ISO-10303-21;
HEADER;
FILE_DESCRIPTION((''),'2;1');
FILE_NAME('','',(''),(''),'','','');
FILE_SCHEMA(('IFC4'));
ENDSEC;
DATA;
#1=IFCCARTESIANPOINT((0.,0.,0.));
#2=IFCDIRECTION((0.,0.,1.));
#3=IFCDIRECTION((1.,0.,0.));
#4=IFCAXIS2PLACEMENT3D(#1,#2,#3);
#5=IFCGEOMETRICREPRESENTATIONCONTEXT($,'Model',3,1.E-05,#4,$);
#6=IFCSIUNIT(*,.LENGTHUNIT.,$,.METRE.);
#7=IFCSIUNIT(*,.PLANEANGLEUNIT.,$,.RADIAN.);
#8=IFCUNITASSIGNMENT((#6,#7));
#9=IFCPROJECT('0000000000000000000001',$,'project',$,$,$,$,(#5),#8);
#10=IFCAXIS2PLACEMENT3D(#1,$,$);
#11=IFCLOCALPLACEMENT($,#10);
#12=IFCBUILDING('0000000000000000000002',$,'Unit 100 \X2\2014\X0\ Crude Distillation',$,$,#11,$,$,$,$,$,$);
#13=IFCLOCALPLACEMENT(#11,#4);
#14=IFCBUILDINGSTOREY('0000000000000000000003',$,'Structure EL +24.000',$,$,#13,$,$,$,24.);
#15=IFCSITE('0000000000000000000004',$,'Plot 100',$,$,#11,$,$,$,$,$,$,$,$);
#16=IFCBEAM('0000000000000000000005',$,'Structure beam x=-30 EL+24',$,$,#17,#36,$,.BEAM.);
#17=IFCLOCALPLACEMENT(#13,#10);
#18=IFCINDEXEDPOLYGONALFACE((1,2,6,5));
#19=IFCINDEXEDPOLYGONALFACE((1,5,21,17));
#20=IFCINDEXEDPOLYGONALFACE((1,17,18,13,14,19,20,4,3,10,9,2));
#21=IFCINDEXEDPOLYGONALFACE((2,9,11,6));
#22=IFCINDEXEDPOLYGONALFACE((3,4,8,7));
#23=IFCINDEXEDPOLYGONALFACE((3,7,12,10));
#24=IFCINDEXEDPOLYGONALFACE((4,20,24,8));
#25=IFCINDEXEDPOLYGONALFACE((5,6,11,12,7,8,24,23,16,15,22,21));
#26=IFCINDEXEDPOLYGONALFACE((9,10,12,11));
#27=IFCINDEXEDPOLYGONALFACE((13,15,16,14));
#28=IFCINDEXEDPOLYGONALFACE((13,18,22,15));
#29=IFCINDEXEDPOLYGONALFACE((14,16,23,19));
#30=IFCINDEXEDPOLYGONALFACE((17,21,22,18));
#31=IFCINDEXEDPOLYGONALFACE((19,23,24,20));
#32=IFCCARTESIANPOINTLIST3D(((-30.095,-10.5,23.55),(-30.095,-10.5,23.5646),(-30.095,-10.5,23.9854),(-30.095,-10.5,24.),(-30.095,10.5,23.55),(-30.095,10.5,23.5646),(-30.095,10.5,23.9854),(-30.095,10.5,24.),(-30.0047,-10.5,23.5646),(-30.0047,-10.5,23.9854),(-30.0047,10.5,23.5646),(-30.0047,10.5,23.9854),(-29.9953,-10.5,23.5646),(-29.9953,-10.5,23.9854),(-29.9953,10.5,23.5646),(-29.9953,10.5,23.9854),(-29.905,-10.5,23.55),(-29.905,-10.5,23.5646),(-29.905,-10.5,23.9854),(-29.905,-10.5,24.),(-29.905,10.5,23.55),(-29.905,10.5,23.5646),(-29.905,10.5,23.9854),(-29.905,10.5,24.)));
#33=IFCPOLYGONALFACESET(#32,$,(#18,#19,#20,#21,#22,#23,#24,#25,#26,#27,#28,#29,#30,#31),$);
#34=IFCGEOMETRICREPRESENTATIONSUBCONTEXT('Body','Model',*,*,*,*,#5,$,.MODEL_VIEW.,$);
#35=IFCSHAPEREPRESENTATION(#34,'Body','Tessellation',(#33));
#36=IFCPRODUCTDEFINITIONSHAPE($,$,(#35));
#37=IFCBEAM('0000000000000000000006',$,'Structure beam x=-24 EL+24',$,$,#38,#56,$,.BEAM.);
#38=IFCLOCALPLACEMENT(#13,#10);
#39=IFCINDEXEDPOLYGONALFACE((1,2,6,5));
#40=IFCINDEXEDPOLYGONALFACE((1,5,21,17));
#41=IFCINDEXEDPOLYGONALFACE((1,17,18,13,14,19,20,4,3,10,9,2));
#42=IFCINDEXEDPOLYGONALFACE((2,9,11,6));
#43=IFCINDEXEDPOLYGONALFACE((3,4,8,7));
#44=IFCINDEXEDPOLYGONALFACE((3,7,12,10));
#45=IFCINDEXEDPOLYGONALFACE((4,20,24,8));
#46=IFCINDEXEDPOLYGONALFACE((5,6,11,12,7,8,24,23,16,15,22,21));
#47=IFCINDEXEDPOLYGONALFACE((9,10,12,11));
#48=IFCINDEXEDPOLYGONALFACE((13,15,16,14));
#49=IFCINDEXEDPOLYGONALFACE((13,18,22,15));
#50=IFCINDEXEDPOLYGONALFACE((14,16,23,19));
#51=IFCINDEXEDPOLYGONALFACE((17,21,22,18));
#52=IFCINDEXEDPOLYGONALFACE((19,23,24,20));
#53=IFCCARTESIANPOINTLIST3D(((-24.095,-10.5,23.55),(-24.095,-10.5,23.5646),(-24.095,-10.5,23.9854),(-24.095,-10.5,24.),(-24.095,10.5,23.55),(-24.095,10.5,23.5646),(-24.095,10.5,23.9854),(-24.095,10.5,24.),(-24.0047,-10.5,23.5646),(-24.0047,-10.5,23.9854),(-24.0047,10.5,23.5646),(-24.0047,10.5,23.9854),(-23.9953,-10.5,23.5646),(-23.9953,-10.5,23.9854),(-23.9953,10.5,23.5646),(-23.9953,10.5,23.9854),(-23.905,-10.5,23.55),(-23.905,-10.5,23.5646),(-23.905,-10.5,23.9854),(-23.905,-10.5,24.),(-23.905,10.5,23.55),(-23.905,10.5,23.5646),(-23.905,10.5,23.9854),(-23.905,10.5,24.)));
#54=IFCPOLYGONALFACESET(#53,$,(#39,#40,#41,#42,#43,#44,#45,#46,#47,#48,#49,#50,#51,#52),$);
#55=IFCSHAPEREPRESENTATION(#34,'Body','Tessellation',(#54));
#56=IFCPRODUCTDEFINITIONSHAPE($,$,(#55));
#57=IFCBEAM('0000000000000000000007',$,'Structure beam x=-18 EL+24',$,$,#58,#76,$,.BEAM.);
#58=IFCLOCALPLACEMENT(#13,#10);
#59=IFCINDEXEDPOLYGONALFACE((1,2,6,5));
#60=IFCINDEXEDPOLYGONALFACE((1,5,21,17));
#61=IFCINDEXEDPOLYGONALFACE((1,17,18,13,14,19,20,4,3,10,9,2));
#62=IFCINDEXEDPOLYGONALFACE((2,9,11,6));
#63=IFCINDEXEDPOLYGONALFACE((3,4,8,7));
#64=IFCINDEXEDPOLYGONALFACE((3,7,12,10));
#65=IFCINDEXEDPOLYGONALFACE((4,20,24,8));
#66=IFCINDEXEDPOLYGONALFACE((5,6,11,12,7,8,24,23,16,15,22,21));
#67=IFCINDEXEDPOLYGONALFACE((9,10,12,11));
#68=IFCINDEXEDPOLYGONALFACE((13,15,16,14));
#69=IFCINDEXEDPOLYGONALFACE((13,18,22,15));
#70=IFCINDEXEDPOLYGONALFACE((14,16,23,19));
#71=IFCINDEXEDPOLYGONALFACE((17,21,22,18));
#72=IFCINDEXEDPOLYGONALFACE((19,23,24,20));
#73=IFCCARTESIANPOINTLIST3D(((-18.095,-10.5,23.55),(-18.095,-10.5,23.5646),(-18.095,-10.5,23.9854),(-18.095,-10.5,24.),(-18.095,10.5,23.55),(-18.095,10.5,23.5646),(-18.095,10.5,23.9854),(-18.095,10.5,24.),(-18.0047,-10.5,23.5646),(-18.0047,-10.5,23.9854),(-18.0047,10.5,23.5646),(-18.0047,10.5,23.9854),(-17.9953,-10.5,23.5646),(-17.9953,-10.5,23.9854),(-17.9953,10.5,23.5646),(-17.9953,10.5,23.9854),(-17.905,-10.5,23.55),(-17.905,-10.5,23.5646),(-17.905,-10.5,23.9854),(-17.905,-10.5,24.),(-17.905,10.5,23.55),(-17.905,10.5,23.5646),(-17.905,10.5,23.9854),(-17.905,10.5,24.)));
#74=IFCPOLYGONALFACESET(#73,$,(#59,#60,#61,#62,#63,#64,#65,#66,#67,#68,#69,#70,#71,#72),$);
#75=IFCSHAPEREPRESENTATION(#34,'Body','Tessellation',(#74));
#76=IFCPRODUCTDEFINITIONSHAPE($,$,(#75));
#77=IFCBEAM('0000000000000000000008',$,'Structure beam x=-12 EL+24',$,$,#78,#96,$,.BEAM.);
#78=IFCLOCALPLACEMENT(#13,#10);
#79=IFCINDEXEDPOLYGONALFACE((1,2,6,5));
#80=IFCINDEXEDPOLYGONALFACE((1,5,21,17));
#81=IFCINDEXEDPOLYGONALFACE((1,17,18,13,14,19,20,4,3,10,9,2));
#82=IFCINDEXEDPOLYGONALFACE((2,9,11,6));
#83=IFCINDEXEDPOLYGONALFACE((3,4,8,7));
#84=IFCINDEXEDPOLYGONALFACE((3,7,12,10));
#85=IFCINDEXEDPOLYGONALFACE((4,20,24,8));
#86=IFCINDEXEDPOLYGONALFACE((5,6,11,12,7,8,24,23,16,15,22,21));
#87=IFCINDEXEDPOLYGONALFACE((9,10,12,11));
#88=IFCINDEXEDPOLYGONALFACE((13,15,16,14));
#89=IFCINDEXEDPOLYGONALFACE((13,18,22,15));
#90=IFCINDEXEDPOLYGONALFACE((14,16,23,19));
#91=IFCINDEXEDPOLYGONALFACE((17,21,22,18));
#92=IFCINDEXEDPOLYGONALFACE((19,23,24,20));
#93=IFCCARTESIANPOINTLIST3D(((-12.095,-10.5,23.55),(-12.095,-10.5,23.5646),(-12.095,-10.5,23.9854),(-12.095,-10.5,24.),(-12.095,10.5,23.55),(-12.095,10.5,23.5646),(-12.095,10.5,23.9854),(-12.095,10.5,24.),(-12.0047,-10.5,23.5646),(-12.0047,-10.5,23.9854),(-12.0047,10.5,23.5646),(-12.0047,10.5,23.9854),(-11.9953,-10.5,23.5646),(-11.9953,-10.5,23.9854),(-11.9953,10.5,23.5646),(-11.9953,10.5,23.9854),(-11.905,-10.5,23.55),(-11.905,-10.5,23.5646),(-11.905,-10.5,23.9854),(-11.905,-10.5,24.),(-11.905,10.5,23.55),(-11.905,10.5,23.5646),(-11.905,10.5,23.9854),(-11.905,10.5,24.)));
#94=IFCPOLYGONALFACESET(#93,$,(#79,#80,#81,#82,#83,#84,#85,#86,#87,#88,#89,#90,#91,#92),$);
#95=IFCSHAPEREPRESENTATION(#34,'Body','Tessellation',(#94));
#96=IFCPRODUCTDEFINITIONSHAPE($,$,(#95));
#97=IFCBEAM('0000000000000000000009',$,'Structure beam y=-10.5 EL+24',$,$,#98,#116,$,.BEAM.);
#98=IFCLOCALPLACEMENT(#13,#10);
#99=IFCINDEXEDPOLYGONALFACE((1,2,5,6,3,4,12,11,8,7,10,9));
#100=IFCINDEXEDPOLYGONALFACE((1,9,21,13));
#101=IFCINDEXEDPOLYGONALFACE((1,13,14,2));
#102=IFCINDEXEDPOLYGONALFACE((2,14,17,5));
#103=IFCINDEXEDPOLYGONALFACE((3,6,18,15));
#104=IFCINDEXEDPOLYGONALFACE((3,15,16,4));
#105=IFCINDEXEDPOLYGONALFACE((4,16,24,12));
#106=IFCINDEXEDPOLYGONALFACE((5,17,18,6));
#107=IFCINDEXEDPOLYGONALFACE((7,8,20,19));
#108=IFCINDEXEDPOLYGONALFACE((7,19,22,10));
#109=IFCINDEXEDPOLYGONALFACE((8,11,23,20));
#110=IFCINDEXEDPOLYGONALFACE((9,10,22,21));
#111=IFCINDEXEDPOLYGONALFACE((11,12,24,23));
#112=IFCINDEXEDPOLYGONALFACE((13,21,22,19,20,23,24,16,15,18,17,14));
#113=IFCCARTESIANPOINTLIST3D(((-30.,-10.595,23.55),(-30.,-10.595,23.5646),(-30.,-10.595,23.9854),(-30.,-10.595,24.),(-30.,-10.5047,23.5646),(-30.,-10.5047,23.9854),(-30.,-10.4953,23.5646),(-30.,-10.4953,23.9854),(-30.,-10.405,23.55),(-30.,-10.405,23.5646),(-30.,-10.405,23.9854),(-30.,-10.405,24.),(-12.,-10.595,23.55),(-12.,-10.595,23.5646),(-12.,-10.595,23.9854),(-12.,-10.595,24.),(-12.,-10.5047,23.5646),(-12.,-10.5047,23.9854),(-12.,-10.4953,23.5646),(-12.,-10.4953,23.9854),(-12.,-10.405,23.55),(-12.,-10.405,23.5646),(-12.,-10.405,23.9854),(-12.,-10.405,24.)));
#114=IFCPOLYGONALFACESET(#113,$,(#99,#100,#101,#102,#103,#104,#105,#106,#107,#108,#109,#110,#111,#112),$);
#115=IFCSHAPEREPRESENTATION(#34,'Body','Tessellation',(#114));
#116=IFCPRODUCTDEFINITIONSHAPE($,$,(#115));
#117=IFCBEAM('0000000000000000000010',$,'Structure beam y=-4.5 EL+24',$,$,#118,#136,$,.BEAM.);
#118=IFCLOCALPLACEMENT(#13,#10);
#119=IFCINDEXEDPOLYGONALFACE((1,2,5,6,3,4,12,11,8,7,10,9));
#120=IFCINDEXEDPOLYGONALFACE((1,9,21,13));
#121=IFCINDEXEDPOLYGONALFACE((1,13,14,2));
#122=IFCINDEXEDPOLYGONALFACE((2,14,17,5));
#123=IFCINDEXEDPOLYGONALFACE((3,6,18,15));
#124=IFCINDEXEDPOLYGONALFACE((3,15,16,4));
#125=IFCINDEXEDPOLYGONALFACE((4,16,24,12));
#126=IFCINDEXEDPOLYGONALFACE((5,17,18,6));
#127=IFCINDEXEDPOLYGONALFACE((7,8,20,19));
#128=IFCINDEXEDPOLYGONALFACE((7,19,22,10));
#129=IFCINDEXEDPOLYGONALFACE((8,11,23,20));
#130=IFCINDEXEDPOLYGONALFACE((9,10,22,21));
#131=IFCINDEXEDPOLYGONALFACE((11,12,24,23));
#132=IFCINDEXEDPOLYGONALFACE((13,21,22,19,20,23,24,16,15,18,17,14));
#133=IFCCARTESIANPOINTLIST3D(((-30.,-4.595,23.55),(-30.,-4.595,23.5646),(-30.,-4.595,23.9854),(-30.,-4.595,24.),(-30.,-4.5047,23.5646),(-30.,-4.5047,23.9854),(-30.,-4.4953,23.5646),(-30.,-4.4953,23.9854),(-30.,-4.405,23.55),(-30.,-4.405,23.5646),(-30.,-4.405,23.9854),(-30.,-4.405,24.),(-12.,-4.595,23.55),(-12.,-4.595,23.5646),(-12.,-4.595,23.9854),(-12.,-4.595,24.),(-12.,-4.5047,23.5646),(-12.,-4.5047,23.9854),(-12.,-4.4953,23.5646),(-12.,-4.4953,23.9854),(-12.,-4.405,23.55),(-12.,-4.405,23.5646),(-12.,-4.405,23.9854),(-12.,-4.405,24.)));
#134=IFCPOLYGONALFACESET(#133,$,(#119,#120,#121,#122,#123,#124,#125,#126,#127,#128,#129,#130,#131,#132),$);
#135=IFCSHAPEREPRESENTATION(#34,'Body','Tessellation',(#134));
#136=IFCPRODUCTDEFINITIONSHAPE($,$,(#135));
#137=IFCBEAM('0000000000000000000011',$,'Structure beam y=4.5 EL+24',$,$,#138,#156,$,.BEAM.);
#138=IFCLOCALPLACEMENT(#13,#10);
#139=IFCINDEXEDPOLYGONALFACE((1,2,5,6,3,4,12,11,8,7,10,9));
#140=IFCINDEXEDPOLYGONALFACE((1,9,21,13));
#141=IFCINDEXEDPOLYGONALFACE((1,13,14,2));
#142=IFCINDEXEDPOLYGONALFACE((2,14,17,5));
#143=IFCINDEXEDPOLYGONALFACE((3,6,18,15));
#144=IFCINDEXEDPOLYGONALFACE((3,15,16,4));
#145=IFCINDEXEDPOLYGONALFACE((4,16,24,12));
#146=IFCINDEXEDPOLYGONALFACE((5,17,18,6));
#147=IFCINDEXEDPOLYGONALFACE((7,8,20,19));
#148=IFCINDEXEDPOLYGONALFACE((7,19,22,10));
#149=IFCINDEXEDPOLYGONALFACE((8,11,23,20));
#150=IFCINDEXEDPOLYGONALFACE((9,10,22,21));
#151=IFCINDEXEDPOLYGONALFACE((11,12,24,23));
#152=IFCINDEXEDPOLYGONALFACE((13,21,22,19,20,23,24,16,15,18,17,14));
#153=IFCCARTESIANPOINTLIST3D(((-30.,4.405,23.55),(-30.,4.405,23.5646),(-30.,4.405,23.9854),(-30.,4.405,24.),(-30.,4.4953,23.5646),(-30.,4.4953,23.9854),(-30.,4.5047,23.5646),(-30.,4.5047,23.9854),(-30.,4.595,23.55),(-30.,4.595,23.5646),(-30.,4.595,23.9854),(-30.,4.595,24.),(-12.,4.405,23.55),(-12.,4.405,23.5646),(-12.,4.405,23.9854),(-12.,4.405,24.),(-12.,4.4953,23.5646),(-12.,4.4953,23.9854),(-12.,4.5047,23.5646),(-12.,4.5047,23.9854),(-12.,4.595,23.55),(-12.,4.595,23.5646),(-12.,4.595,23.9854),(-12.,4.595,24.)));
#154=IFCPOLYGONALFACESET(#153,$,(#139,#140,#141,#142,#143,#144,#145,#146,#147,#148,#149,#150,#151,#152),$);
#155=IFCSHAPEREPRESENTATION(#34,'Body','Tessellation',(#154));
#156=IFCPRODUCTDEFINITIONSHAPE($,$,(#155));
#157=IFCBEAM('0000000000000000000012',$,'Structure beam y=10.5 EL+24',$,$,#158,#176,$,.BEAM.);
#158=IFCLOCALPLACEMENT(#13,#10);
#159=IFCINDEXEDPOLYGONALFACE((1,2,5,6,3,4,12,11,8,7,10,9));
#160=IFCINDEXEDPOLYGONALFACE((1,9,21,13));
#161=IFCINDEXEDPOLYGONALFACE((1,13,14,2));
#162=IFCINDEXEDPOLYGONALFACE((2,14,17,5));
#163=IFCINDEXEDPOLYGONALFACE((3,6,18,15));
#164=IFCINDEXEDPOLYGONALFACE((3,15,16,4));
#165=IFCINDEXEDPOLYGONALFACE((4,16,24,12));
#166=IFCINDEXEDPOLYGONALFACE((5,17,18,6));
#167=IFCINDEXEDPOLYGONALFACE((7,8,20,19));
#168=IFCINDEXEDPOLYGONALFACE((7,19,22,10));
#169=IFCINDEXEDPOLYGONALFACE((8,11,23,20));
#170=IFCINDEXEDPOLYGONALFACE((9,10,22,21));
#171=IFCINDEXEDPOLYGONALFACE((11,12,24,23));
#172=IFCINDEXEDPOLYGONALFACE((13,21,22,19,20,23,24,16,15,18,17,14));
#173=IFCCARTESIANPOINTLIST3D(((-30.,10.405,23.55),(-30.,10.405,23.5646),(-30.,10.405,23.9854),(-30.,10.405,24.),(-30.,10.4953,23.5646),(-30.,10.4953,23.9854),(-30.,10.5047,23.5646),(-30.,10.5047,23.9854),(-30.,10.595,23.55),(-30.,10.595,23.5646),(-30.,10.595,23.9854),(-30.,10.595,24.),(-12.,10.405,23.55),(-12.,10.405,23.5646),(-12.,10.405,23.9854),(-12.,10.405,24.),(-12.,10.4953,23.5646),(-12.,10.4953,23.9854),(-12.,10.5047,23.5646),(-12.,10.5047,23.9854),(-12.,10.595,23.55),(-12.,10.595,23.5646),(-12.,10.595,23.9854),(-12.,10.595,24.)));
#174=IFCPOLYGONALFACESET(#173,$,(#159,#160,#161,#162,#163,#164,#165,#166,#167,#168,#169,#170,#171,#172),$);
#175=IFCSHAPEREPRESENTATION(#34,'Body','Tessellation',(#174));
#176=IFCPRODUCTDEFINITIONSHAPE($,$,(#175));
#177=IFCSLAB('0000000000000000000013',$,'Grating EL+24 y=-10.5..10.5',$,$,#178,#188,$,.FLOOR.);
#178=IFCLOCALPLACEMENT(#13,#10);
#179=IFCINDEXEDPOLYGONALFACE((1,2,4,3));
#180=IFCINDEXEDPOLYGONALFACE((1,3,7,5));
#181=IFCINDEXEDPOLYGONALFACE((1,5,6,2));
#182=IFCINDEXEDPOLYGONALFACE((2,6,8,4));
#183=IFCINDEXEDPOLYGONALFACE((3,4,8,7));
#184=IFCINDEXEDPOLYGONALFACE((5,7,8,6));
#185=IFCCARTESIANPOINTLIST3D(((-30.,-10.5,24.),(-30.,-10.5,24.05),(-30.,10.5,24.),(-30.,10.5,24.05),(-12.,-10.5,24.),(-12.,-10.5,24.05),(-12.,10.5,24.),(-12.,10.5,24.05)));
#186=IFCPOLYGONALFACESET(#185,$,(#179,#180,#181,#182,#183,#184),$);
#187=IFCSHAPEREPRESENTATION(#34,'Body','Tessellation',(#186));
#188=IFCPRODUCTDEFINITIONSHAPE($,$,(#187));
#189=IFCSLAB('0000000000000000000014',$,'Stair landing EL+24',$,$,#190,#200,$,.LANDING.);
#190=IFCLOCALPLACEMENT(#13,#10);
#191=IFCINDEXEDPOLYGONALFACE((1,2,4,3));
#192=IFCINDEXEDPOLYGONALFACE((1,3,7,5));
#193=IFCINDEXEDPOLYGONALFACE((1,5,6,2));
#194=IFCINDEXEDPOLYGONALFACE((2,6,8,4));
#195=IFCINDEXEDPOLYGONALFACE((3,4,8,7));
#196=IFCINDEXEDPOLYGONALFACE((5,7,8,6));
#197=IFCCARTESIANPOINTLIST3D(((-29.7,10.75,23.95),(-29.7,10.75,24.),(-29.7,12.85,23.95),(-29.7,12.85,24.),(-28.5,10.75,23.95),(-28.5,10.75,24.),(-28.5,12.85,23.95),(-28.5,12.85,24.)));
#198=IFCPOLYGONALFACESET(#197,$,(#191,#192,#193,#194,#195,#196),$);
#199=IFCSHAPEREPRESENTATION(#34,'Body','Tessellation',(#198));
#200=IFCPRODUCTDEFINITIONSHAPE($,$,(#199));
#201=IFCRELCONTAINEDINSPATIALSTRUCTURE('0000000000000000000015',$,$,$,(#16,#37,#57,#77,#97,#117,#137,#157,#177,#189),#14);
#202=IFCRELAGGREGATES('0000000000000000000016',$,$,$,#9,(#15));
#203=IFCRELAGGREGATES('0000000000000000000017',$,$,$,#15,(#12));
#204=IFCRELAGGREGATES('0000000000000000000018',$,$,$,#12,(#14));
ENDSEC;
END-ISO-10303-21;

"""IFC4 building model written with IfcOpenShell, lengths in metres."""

from ifc_helpers import new_model, si_unit, frame, origin, origin_with_axes, origin_2d, place, context, subcontext, project, spatial, rectangle, i_section, extrude, element, save


model = new_model("IFC4")

# Units and contexts
model_context = context("Model", 3, precision=1e-05, world=origin_with_axes())
body_context = subcontext(model_context, "Body", "Model", "MODEL_VIEW")
ifc_project = project(units=[si_unit("LENGTHUNIT", "METRE"), si_unit("PLANEANGLEUNIT", "RADIAN")], contexts=[model_context])

# Site, building, storey
placement = place(None, origin())
site = spatial("IfcSite", under=ifc_project, at=placement, Name="Plot 100")
building = spatial("IfcBuilding", under=site, at=placement, Name="Unit 100 — Crude Distillation")
storey_placement = place(placement, origin_with_axes())
storey = spatial("IfcBuildingStorey", under=building, at=storey_placement, Name="Structure EL +24.000", Elevation=24.0)

# Beams
beam_1_placement = place(storey_placement, origin_with_axes())
element("IfcBeam", 1, at=beam_1_placement, inside=storey, Name="Structure beam x=-30 EL+24", PredefinedType="BEAM", context=body_context, shape_type="SweptSolid", body=[
    extrude(i_section(OverallWidth=0.19, OverallDepth=0.45, WebThickness=0.0094, FlangeThickness=0.0146, at=origin_2d()), frame((-30.0, -10.5, 23.775), z_axis=(0.0, 1.0, 0.0), x_axis=(-1.0, 0.0, 0.0)), (0.0, 0.0, 1.0), 21.0),
])
beam_2_placement = place(storey_placement, origin_with_axes())
element("IfcBeam", 2, at=beam_2_placement, inside=storey, Name="Structure beam x=-24 EL+24", PredefinedType="BEAM", context=body_context, shape_type="SweptSolid", body=[
    extrude(i_section(OverallWidth=0.19, OverallDepth=0.45, WebThickness=0.0094, FlangeThickness=0.0146, at=origin_2d()), frame((-24.0, -10.5, 23.775), z_axis=(0.0, 1.0, 0.0), x_axis=(-1.0, 0.0, 0.0)), (0.0, 0.0, 1.0), 21.0),
])
beam_3_placement = place(storey_placement, origin_with_axes())
element("IfcBeam", 3, at=beam_3_placement, inside=storey, Name="Structure beam x=-18 EL+24", PredefinedType="BEAM", context=body_context, shape_type="SweptSolid", body=[
    extrude(i_section(OverallWidth=0.19, OverallDepth=0.45, WebThickness=0.0094, FlangeThickness=0.0146, at=origin_2d()), frame((-18.0, -10.5, 23.775), z_axis=(0.0, 1.0, 0.0), x_axis=(-1.0, 0.0, 0.0)), (0.0, 0.0, 1.0), 21.0),
])
beam_4_placement = place(storey_placement, origin_with_axes())
element("IfcBeam", 4, at=beam_4_placement, inside=storey, Name="Structure beam x=-12 EL+24", PredefinedType="BEAM", context=body_context, shape_type="SweptSolid", body=[
    extrude(i_section(OverallWidth=0.19, OverallDepth=0.45, WebThickness=0.0094, FlangeThickness=0.0146, at=origin_2d()), frame((-12.0, -10.5, 23.775), z_axis=(0.0, 1.0, 0.0), x_axis=(-1.0, 0.0, 0.0)), (0.0, 0.0, 1.0), 21.0),
])
beam_5_placement = place(storey_placement, origin_with_axes())
element("IfcBeam", 5, at=beam_5_placement, inside=storey, Name="Structure beam y=-10.5 EL+24", PredefinedType="BEAM", context=body_context, shape_type="SweptSolid", body=[
    extrude(i_section(OverallWidth=0.19, OverallDepth=0.45, WebThickness=0.0094, FlangeThickness=0.0146, at=origin_2d()), frame((-30.0, -10.5, 23.775), z_axis=(1.0, 0.0, 0.0), x_axis=(0.0, 1.0, 0.0)), (0.0, 0.0, 1.0), 18.0),
])
beam_6_placement = place(storey_placement, origin_with_axes())
element("IfcBeam", 6, at=beam_6_placement, inside=storey, Name="Structure beam y=-4.5 EL+24", PredefinedType="BEAM", context=body_context, shape_type="SweptSolid", body=[
    extrude(i_section(OverallWidth=0.19, OverallDepth=0.45, WebThickness=0.0094, FlangeThickness=0.0146, at=origin_2d()), frame((-30.0, -4.5, 23.775), z_axis=(1.0, 0.0, 0.0), x_axis=(0.0, 1.0, 0.0)), (0.0, 0.0, 1.0), 18.0),
])
beam_7_placement = place(storey_placement, origin_with_axes())
element("IfcBeam", 7, at=beam_7_placement, inside=storey, Name="Structure beam y=4.5 EL+24", PredefinedType="BEAM", context=body_context, shape_type="SweptSolid", body=[
    extrude(i_section(OverallWidth=0.19, OverallDepth=0.45, WebThickness=0.0094, FlangeThickness=0.0146, at=origin_2d()), frame((-30.0, 4.5, 23.775), z_axis=(1.0, 0.0, 0.0), x_axis=(0.0, 1.0, 0.0)), (0.0, 0.0, 1.0), 18.0),
])
beam_8_placement = place(storey_placement, origin_with_axes())
element("IfcBeam", 8, at=beam_8_placement, inside=storey, Name="Structure beam y=10.5 EL+24", PredefinedType="BEAM", context=body_context, shape_type="SweptSolid", body=[
    extrude(i_section(OverallWidth=0.19, OverallDepth=0.45, WebThickness=0.0094, FlangeThickness=0.0146, at=origin_2d()), frame((-30.0, 10.5, 23.775), z_axis=(1.0, 0.0, 0.0), x_axis=(0.0, 1.0, 0.0)), (0.0, 0.0, 1.0), 18.0),
])

# Slabs
slab_1_placement = place(storey_placement, origin_with_axes())
element("IfcSlab", 9, at=slab_1_placement, inside=storey, Name="Grating EL+24 y=-10.5..10.5", PredefinedType="FLOOR", context=body_context, shape_type="SweptSolid", body=[
    extrude(rectangle(XDim=18.0, YDim=21.0, at=origin_2d()), frame((-21.0, 0.0, 24.0), z_axis=(0.0, 0.0, 1.0), x_axis=(1.0, 0.0, 0.0)), (0.0, 0.0, 1.0), 0.05),
])
slab_2_placement = place(storey_placement, origin_with_axes())
element("IfcSlab", 10, at=slab_2_placement, inside=storey, Name="Stair landing EL+24", PredefinedType="LANDING", context=body_context, shape_type="SweptSolid", body=[
    extrude(rectangle(XDim=1.2, YDim=2.1, at=origin_2d()), frame((-29.1, 11.8, 23.95), z_axis=(0.0, 0.0, 1.0), x_axis=(1.0, 0.0, 0.0)), (0.0, 0.0, 1.0), 0.05),
])

save(model, "model.ifc")
